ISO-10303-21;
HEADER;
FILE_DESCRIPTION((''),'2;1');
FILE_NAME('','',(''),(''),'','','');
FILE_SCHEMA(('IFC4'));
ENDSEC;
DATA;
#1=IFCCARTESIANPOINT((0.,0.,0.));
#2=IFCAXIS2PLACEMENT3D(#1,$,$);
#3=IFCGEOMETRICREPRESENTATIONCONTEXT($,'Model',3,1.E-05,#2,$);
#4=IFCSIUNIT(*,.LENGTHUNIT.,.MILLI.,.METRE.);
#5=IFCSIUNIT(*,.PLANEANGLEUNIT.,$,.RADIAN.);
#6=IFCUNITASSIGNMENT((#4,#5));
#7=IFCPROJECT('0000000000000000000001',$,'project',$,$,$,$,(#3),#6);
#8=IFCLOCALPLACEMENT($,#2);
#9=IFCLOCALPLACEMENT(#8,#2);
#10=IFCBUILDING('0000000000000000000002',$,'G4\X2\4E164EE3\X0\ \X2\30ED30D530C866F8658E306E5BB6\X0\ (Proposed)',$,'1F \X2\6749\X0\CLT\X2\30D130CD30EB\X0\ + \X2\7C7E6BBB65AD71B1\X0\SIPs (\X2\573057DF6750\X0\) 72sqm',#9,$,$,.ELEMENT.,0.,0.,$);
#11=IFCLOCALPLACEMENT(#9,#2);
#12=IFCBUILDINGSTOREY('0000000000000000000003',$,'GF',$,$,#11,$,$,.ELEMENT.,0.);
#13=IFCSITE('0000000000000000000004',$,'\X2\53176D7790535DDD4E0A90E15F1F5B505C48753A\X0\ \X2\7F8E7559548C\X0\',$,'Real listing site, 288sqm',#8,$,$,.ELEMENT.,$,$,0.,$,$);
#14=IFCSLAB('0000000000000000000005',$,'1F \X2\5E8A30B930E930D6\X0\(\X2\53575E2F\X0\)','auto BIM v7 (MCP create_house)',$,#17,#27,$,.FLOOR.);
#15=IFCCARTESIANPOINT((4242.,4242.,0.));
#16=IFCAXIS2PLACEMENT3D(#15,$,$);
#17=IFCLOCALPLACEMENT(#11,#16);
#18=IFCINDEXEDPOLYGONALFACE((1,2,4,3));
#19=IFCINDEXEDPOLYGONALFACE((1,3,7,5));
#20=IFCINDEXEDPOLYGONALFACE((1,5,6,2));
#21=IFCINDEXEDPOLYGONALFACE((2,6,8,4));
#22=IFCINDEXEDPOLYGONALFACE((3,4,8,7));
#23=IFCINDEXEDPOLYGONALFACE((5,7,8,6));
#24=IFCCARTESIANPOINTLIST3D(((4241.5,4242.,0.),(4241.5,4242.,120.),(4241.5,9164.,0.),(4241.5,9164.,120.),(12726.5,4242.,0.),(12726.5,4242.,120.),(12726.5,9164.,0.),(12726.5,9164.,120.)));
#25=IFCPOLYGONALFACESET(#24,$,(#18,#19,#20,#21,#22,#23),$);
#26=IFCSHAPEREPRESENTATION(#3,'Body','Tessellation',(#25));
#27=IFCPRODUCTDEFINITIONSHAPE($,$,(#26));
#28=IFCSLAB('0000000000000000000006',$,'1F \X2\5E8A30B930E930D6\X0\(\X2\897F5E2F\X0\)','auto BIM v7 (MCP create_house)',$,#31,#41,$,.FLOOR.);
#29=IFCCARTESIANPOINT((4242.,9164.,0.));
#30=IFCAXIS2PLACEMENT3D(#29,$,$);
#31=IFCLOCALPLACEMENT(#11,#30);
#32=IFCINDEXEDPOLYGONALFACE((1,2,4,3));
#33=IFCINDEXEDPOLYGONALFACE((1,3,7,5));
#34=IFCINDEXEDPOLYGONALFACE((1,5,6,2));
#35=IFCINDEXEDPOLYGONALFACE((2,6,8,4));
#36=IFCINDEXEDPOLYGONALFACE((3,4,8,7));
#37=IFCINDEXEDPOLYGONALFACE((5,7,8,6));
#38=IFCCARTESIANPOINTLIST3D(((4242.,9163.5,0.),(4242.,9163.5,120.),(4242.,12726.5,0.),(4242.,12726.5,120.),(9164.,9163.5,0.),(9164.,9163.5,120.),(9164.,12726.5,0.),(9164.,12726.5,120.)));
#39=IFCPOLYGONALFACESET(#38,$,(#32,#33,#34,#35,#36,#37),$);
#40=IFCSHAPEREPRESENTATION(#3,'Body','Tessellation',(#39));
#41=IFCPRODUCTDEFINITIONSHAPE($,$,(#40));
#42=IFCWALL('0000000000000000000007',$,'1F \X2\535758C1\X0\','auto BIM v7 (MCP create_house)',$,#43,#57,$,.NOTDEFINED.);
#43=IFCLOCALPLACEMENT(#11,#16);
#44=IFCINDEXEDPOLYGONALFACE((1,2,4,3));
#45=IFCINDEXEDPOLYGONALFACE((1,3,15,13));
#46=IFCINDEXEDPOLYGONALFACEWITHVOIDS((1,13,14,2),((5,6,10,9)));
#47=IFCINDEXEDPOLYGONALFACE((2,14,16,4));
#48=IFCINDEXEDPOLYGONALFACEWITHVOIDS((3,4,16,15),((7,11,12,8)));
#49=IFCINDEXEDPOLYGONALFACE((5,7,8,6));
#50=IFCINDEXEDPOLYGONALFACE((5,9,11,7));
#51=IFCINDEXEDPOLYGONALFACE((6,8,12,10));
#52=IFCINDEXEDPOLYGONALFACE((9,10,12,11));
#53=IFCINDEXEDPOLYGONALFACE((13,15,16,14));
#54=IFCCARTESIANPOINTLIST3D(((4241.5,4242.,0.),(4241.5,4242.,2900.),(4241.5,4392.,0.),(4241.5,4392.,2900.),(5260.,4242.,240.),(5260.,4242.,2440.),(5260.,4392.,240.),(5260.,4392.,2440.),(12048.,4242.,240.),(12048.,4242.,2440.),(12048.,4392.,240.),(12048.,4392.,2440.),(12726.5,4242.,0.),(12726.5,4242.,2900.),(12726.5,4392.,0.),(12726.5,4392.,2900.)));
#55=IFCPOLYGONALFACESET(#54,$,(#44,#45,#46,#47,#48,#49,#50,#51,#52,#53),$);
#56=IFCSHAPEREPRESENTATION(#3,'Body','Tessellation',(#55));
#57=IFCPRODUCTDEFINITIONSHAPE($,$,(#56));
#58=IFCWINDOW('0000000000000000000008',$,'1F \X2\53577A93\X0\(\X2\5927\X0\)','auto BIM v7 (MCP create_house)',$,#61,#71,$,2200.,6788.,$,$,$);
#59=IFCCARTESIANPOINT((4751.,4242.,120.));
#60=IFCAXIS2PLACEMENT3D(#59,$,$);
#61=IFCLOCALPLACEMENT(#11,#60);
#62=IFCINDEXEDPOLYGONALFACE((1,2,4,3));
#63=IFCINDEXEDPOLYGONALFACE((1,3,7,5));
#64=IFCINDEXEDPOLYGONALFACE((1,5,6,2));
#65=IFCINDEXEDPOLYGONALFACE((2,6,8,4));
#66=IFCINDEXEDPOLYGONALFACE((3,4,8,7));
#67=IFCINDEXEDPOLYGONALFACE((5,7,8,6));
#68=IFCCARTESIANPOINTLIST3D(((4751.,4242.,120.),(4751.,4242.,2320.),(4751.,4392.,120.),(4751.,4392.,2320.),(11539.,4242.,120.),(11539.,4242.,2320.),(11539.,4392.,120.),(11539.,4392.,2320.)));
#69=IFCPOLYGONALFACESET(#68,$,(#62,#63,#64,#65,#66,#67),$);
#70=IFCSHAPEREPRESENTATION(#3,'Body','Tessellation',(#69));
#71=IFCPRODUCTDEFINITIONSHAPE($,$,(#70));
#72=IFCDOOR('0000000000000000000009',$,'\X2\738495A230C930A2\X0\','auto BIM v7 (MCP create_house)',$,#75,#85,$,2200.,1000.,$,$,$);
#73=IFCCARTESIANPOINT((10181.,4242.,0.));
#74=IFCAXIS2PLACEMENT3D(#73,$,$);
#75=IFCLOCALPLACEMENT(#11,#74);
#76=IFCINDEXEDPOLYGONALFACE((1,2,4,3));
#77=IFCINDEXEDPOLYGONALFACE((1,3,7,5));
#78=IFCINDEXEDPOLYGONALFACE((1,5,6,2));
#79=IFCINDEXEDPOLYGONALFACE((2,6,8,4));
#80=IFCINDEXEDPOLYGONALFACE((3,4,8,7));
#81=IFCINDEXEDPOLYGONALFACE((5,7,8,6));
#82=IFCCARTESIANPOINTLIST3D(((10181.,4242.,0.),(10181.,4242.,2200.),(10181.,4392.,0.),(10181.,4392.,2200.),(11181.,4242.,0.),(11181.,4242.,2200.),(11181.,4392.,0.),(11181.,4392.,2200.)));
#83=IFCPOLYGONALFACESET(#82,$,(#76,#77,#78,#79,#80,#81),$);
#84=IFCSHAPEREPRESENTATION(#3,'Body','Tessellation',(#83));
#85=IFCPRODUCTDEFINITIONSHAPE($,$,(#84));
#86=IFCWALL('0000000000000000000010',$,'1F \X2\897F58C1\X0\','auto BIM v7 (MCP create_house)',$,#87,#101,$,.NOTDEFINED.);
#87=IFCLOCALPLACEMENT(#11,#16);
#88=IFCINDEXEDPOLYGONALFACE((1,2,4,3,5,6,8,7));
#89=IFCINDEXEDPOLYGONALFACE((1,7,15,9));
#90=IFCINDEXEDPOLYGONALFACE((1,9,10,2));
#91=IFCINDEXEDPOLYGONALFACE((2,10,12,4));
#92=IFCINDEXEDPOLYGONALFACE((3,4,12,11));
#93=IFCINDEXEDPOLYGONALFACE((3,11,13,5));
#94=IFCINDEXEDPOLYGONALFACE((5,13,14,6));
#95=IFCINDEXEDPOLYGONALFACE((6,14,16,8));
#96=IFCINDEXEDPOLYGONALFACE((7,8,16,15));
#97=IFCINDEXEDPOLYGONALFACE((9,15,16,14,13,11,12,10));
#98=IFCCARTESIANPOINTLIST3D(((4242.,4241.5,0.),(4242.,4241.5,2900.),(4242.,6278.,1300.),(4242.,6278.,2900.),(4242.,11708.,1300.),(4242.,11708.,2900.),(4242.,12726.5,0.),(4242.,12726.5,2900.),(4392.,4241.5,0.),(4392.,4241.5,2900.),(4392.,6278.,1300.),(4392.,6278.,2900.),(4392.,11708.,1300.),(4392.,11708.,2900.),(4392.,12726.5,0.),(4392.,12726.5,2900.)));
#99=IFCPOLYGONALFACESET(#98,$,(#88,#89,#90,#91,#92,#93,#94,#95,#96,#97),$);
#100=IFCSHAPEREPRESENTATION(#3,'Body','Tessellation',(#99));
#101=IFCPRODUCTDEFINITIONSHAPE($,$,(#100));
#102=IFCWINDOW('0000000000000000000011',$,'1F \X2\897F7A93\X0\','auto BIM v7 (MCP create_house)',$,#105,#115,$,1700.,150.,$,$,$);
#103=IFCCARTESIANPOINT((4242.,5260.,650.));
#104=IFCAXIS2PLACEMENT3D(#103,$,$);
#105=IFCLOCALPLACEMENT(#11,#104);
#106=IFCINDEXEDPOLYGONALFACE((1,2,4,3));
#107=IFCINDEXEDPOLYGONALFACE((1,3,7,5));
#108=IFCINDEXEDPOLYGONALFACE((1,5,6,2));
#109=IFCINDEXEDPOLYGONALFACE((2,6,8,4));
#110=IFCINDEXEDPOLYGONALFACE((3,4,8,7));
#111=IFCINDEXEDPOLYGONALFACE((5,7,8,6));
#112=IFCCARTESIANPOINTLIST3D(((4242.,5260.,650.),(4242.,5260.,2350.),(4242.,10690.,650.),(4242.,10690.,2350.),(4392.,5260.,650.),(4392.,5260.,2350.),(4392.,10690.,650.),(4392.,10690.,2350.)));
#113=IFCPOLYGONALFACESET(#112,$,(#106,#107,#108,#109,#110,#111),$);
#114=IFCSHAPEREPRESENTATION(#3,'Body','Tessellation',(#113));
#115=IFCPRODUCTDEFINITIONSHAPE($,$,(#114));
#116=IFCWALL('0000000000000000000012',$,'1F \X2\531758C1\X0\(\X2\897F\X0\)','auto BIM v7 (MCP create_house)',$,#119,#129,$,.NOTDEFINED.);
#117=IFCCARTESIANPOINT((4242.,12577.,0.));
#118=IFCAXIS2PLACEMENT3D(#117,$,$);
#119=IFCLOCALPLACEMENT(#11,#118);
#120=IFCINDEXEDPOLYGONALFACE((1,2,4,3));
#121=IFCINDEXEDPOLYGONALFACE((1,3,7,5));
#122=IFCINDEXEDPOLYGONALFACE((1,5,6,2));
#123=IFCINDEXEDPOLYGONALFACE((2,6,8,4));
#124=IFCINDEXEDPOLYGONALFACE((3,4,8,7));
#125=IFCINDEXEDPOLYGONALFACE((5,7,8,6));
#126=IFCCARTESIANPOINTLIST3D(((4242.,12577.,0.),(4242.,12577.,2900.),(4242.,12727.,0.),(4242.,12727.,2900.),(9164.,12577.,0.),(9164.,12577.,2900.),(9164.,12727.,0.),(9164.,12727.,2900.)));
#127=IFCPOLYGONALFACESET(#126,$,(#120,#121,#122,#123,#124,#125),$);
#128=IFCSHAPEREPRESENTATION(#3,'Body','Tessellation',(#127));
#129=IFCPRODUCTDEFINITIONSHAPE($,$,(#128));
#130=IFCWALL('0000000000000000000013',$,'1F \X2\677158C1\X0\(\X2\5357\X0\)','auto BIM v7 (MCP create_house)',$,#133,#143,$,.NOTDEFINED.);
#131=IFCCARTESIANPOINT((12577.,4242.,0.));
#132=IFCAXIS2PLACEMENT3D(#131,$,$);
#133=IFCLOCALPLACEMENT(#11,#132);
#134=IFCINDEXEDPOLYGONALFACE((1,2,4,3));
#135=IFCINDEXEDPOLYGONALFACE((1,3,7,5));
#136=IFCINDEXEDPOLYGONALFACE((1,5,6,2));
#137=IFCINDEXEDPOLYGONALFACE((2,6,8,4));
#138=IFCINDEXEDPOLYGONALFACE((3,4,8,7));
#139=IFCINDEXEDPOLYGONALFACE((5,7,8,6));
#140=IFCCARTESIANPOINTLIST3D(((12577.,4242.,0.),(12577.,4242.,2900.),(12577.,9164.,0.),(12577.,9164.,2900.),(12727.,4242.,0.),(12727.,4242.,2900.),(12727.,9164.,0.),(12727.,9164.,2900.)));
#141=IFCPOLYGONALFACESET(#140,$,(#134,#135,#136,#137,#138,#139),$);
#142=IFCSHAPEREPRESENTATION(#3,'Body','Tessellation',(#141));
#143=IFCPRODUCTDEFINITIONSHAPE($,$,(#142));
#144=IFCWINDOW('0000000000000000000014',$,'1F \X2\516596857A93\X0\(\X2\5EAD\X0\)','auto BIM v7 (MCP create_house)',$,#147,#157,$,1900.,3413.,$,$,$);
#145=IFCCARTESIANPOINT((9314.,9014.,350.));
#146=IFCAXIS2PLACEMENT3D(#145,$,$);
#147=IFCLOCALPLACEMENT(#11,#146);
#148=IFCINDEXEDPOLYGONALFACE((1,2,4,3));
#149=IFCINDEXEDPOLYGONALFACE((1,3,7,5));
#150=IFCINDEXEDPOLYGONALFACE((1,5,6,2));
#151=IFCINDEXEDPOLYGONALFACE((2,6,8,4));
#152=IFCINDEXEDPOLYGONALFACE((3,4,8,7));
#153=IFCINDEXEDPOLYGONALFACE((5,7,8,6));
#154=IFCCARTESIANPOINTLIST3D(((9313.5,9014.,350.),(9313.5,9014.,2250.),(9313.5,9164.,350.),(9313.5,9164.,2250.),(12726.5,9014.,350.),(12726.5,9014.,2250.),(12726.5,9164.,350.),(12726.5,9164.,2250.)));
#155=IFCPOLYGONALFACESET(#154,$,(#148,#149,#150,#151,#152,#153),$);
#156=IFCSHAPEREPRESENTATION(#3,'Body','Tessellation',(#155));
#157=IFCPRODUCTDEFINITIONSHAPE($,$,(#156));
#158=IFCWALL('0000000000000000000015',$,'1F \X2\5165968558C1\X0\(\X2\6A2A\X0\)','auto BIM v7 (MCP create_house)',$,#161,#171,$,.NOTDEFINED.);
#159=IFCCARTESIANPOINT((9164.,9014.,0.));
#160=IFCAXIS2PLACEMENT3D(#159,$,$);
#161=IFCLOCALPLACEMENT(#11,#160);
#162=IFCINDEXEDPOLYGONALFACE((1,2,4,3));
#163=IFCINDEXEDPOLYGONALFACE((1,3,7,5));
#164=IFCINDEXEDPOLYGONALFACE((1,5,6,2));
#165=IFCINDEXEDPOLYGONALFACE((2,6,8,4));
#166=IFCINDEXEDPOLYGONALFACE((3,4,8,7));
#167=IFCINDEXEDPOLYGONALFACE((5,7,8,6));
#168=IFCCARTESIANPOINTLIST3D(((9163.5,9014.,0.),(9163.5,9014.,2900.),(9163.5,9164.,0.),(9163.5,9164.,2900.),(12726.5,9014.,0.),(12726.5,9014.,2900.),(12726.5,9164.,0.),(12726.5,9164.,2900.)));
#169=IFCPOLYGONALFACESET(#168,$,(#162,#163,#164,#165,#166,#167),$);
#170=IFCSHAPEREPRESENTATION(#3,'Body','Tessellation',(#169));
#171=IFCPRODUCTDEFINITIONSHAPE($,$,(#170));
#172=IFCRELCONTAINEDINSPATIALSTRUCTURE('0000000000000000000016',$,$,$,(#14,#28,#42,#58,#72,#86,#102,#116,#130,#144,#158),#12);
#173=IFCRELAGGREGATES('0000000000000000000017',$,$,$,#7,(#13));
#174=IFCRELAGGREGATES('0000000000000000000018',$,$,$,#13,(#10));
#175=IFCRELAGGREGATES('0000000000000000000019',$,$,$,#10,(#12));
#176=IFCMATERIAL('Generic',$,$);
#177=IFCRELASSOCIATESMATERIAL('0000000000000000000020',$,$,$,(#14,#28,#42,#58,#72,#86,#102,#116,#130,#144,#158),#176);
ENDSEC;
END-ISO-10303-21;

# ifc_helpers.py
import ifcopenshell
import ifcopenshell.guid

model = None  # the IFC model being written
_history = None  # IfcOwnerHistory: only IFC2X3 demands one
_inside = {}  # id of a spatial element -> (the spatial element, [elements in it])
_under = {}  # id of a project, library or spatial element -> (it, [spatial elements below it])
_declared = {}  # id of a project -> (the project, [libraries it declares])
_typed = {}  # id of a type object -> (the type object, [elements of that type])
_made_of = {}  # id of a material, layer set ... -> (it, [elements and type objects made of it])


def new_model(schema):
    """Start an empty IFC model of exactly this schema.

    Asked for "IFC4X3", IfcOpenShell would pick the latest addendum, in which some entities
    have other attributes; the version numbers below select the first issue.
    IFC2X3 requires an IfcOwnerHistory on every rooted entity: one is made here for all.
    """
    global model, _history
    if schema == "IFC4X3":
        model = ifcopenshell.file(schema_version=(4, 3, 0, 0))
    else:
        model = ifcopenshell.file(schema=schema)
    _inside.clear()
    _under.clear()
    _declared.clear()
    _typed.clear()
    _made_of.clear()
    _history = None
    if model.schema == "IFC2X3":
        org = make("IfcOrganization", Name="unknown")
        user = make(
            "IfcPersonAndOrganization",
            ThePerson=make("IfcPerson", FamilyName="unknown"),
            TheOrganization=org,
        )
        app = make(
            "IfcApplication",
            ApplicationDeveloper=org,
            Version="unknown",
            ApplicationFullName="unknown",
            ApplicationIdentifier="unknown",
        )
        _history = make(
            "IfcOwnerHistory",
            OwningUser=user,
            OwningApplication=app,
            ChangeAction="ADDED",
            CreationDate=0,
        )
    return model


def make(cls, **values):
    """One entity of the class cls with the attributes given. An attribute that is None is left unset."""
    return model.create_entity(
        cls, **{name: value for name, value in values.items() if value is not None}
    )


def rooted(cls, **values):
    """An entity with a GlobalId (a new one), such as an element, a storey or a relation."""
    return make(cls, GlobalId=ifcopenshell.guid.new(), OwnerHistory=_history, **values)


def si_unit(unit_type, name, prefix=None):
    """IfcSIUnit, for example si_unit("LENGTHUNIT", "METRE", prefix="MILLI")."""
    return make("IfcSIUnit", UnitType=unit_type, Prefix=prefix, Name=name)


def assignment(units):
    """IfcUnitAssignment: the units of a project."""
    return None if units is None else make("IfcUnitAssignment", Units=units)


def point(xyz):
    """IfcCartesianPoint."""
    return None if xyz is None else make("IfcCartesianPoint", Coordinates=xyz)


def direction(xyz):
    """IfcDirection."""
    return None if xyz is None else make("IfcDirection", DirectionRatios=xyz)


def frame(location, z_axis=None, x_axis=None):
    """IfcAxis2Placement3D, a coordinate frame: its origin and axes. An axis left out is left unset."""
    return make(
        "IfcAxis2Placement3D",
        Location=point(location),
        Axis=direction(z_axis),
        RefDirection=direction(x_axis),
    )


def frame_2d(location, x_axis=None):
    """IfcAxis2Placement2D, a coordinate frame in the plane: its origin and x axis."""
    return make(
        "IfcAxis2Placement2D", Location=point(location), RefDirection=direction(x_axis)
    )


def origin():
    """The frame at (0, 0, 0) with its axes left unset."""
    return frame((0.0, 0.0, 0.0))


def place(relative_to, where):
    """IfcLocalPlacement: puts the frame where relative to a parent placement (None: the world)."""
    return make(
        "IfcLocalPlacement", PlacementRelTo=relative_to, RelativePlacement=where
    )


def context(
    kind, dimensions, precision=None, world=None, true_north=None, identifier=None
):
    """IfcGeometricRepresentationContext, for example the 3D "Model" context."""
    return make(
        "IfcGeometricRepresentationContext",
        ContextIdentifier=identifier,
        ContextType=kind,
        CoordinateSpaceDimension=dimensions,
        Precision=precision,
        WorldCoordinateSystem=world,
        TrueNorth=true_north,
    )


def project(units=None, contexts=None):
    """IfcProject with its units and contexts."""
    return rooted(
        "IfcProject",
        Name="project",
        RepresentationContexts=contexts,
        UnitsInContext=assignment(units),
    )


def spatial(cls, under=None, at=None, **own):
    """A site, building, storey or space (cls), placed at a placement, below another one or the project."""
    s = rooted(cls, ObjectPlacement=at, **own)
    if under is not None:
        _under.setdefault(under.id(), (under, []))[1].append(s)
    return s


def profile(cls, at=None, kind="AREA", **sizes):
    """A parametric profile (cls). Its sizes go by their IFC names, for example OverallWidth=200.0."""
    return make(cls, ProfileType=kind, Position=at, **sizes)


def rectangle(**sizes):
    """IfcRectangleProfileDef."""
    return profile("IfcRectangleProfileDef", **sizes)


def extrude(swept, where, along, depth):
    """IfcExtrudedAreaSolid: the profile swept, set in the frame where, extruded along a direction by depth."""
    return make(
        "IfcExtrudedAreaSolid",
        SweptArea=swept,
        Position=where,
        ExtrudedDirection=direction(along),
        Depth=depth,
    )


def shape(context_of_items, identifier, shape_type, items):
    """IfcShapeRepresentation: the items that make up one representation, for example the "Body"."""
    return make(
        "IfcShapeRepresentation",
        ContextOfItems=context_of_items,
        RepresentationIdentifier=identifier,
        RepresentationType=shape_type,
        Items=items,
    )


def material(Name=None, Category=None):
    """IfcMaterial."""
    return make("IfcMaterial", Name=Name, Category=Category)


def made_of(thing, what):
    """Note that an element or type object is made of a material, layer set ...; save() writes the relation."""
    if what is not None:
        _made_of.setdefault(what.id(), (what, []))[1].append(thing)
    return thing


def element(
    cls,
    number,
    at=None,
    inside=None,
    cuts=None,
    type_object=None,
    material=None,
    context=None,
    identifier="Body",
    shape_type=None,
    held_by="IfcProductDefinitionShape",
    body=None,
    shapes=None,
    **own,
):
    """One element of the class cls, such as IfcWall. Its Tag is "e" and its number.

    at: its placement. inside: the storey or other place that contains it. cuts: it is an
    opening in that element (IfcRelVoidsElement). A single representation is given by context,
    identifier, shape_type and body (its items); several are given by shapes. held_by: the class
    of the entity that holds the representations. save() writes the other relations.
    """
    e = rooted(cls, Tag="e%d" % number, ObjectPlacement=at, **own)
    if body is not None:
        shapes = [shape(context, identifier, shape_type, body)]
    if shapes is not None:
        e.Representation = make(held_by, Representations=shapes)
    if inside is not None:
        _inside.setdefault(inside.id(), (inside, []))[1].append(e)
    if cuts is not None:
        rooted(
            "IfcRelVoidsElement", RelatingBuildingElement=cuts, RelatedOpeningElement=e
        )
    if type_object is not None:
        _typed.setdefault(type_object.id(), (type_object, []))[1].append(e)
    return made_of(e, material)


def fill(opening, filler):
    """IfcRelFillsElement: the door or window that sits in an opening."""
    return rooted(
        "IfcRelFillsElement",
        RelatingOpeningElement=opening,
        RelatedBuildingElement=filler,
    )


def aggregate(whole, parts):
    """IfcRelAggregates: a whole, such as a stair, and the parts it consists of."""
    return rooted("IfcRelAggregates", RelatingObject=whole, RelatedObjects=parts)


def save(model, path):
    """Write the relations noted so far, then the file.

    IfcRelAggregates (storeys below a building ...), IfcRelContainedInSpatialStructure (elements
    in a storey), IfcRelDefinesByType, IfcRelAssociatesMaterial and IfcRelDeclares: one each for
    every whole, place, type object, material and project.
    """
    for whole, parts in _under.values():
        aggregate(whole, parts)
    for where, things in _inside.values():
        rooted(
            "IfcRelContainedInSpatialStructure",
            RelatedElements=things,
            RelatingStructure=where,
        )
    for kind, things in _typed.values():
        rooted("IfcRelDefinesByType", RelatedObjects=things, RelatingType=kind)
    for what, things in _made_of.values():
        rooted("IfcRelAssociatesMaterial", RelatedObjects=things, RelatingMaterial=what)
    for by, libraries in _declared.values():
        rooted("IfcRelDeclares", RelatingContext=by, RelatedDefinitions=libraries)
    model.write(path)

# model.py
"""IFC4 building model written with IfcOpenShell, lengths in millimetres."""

from ifc_helpers import new_model, si_unit, frame, frame_2d, origin, place, context, project, spatial, rectangle, extrude, material, element, fill, save


model = new_model("IFC4")

# Units and contexts
model_context = context("Model", 3, precision=1e-05, world=origin())
ifc_project = project(units=[si_unit("LENGTHUNIT", "METRE", prefix="MILLI"), si_unit("PLANEANGLEUNIT", "RADIAN")], contexts=[model_context])

# Site, building, storey
site_placement = place(None, origin())
site = spatial("IfcSite", under=ifc_project, at=site_placement, Name="北海道川上郡弟子屈町 美留和", ObjectType="Real listing site, 288sqm", CompositionType="ELEMENT", RefElevation=0.0)
building_placement = place(site_placement, origin())
building = spatial("IfcBuilding", under=site, at=building_placement, Name="G4世代 ロフト書斎の家 (Proposed)", ObjectType="1F 杉CLTパネル + 籾殻断熱SIPs (地域材) 72sqm", CompositionType="ELEMENT", ElevationOfRefHeight=0.0, ElevationOfTerrain=0.0)
storey_placement = place(building_placement, origin())
storey = spatial("IfcBuildingStorey", under=building, at=storey_placement, Name="GF", CompositionType="ELEMENT", Elevation=0.0)

# Slabs
ifc_material = material(Name="Generic")
slab_1_placement = place(storey_placement, frame((4242.0, 4242.0, 0.0)))
element("IfcSlab", 1, at=slab_1_placement, inside=storey, material=ifc_material, Name="1F 床スラブ(南帯)", Description="auto BIM v7 (MCP create_house)", PredefinedType="FLOOR", context=model_context, shape_type="SweptSolid", body=[
    extrude(rectangle(XDim=8485.0, YDim=4922.0, at=frame_2d((4242.0, 2461.0))), frame((4242.0, 4242.0, 0.0)), (0.0, 0.0, 1.0), 120.0),
])
slab_2_placement = place(storey_placement, frame((4242.0, 9164.0, 0.0)))
element("IfcSlab", 2, at=slab_2_placement, inside=storey, material=ifc_material, Name="1F 床スラブ(西帯)", Description="auto BIM v7 (MCP create_house)", PredefinedType="FLOOR", context=model_context, shape_type="SweptSolid", body=[
    extrude(rectangle(XDim=4922.0, YDim=3563.0, at=frame_2d((2461.0, 1781.0))), frame((4242.0, 9164.0, 0.0)), (0.0, 0.0, 1.0), 120.0),
])

# Wall, openings, window, door
wall_1_placement = place(storey_placement, frame((4242.0, 4242.0, 0.0)))
wall_1 = element("IfcWall", 3, at=wall_1_placement, inside=storey, material=ifc_material, Name="1F 南壁", Description="auto BIM v7 (MCP create_house)", PredefinedType="NOTDEFINED", context=model_context, shape_type="SweptSolid", body=[
    extrude(rectangle(XDim=8485.0, YDim=150.0, at=frame_2d((4242.0, 75.0))), frame((4242.0, 4242.0, 0.0)), (0.0, 0.0, 1.0), 2900.0),
])
opening_1_placement = place(storey_placement, frame((4751.0, 4242.0, 120.0)))
opening_1 = element("IfcOpeningElement", 4, at=opening_1_placement, cuts=wall_1, PredefinedType="NOTDEFINED", context=model_context, shape_type="SweptSolid", body=[
    extrude(rectangle(XDim=6788.0, YDim=150.0, at=frame_2d((3394.0, 75.0))), frame((4751.0, 4242.0, 120.0)), (0.0, 0.0, 1.0), 2200.0),
])
opening_2_placement = place(storey_placement, frame((10181.0, 4242.0, 0.0)))
opening_2 = element("IfcOpeningElement", 5, at=opening_2_placement, cuts=wall_1, PredefinedType="NOTDEFINED", context=model_context, shape_type="SweptSolid", body=[
    extrude(rectangle(XDim=1000.0, YDim=150.0, at=frame_2d((500.0, 75.0))), frame((10181.0, 4242.0, 0.0)), (0.0, 0.0, 1.0), 2200.0),
])
window_1_placement = place(storey_placement, frame((4751.0, 4242.0, 120.0)))
window_1 = element("IfcWindow", 6, at=window_1_placement, inside=storey, material=ifc_material, Name="1F 南窓(大)", Description="auto BIM v7 (MCP create_house)", OverallHeight=2200.0, OverallWidth=6788.0, context=model_context, shape_type="SweptSolid", body=[
    extrude(rectangle(XDim=6788.0, YDim=150.0, at=frame_2d((3394.0, 75.0))), frame((4751.0, 4242.0, 120.0)), (0.0, 0.0, 1.0), 2200.0),
])
fill(opening_1, window_1)
door_placement = place(storey_placement, frame((10181.0, 4242.0, 0.0)))
door = element("IfcDoor", 7, at=door_placement, inside=storey, material=ifc_material, Name="玄関ドア", Description="auto BIM v7 (MCP create_house)", OverallHeight=2200.0, OverallWidth=1000.0, context=model_context, shape_type="SweptSolid", body=[
    extrude(rectangle(XDim=1000.0, YDim=150.0, at=frame_2d((500.0, 75.0))), frame((10181.0, 4242.0, 0.0)), (0.0, 0.0, 1.0), 2200.0),
])
fill(opening_2, door)

# Wall, opening, window
wall_2_placement = place(storey_placement, frame((4242.0, 4242.0, 0.0)))
wall_2 = element("IfcWall", 8, at=wall_2_placement, inside=storey, material=ifc_material, Name="1F 西壁", Description="auto BIM v7 (MCP create_house)", PredefinedType="NOTDEFINED", context=model_context, shape_type="SweptSolid", body=[
    extrude(rectangle(XDim=150.0, YDim=8485.0, at=frame_2d((75.0, 4242.0))), frame((4242.0, 4242.0, 0.0)), (0.0, 0.0, 1.0), 2900.0),
])
opening_3_placement = place(storey_placement, frame((4242.0, 5260.0, 650.0)))
opening_3 = element("IfcOpeningElement", 9, at=opening_3_placement, cuts=wall_2, PredefinedType="NOTDEFINED", context=model_context, shape_type="SweptSolid", body=[
    extrude(rectangle(XDim=150.0, YDim=5430.0, at=frame_2d((75.0, 2715.0))), frame((4242.0, 5260.0, 650.0)), (0.0, 0.0, 1.0), 1700.0),
])
window_2_placement = place(storey_placement, frame((4242.0, 5260.0, 650.0)))
window_2 = element("IfcWindow", 10, at=window_2_placement, inside=storey, material=ifc_material, Name="1F 西窓", Description="auto BIM v7 (MCP create_house)", OverallHeight=1700.0, OverallWidth=150.0, context=model_context, shape_type="SweptSolid", body=[
    extrude(rectangle(XDim=150.0, YDim=5430.0, at=frame_2d((75.0, 2715.0))), frame((4242.0, 5260.0, 650.0)), (0.0, 0.0, 1.0), 1700.0),
])
fill(opening_3, window_2)

# Wall
wall_3_placement = place(storey_placement, frame((4242.0, 12577.0, 0.0)))
element("IfcWall", 11, at=wall_3_placement, inside=storey, material=ifc_material, Name="1F 北壁(西)", Description="auto BIM v7 (MCP create_house)", PredefinedType="NOTDEFINED", context=model_context, shape_type="SweptSolid", body=[
    extrude(rectangle(XDim=4922.0, YDim=150.0, at=frame_2d((2461.0, 75.0))), frame((4242.0, 12577.0, 0.0)), (0.0, 0.0, 1.0), 2900.0),
])

# Wall, opening, window
wall_4_placement = place(storey_placement, frame((12577.0, 4242.0, 0.0)))
wall_4 = element("IfcWall", 12, at=wall_4_placement, inside=storey, material=ifc_material, Name="1F 東壁(南)", Description="auto BIM v7 (MCP create_house)", PredefinedType="NOTDEFINED", context=model_context, shape_type="SweptSolid", body=[
    extrude(rectangle(XDim=150.0, YDim=4922.0, at=frame_2d((75.0, 2461.0))), frame((12577.0, 4242.0, 0.0)), (0.0, 0.0, 1.0), 2900.0),
])
opening_4_placement = place(storey_placement, frame((9314.0, 9014.0, 350.0)))
opening_4 = element("IfcOpeningElement", 13, at=opening_4_placement, cuts=wall_4, PredefinedType="NOTDEFINED", context=model_context, shape_type="SweptSolid", body=[
    extrude(rectangle(XDim=3413.0, YDim=150.0, at=frame_2d((1706.0, 75.0))), frame((9314.0, 9014.0, 350.0)), (0.0, 0.0, 1.0), 1900.0),
])
window_3_placement = place(storey_placement, frame((9314.0, 9014.0, 350.0)))
window_3 = element("IfcWindow", 14, at=window_3_placement, inside=storey, material=ifc_material, Name="1F 入隅窓(庭)", Description="auto BIM v7 (MCP create_house)", OverallHeight=1900.0, OverallWidth=3413.0, context=model_context, shape_type="SweptSolid", body=[
    extrude(rectangle(XDim=3413.0, YDim=150.0, at=frame_2d((1706.0, 75.0))), frame((9314.0, 9014.0, 350.0)), (0.0, 0.0, 1.0), 1900.0),
])
fill(opening_4, window_3)

# Wall
wall_5_placement = place(storey_placement, frame((9164.0, 9014.0, 0.0)))
element("IfcWall", 15, at=wall_5_placement, inside=storey, material=ifc_material, Name="1F 入隅壁(横)", Description="auto BIM v7 (MCP create_house)", PredefinedType="NOTDEFINED", context=model_context, shape_type="SweptSolid", body=[
    extrude(rectangle(XDim=3563.0, YDim=150.0, at=frame_2d((1781.0, 75.0))), frame((9164.0, 9014.0, 0.0)), (0.0, 0.0, 1.0), 2900.0),
])

save(model, "model.ifc")
